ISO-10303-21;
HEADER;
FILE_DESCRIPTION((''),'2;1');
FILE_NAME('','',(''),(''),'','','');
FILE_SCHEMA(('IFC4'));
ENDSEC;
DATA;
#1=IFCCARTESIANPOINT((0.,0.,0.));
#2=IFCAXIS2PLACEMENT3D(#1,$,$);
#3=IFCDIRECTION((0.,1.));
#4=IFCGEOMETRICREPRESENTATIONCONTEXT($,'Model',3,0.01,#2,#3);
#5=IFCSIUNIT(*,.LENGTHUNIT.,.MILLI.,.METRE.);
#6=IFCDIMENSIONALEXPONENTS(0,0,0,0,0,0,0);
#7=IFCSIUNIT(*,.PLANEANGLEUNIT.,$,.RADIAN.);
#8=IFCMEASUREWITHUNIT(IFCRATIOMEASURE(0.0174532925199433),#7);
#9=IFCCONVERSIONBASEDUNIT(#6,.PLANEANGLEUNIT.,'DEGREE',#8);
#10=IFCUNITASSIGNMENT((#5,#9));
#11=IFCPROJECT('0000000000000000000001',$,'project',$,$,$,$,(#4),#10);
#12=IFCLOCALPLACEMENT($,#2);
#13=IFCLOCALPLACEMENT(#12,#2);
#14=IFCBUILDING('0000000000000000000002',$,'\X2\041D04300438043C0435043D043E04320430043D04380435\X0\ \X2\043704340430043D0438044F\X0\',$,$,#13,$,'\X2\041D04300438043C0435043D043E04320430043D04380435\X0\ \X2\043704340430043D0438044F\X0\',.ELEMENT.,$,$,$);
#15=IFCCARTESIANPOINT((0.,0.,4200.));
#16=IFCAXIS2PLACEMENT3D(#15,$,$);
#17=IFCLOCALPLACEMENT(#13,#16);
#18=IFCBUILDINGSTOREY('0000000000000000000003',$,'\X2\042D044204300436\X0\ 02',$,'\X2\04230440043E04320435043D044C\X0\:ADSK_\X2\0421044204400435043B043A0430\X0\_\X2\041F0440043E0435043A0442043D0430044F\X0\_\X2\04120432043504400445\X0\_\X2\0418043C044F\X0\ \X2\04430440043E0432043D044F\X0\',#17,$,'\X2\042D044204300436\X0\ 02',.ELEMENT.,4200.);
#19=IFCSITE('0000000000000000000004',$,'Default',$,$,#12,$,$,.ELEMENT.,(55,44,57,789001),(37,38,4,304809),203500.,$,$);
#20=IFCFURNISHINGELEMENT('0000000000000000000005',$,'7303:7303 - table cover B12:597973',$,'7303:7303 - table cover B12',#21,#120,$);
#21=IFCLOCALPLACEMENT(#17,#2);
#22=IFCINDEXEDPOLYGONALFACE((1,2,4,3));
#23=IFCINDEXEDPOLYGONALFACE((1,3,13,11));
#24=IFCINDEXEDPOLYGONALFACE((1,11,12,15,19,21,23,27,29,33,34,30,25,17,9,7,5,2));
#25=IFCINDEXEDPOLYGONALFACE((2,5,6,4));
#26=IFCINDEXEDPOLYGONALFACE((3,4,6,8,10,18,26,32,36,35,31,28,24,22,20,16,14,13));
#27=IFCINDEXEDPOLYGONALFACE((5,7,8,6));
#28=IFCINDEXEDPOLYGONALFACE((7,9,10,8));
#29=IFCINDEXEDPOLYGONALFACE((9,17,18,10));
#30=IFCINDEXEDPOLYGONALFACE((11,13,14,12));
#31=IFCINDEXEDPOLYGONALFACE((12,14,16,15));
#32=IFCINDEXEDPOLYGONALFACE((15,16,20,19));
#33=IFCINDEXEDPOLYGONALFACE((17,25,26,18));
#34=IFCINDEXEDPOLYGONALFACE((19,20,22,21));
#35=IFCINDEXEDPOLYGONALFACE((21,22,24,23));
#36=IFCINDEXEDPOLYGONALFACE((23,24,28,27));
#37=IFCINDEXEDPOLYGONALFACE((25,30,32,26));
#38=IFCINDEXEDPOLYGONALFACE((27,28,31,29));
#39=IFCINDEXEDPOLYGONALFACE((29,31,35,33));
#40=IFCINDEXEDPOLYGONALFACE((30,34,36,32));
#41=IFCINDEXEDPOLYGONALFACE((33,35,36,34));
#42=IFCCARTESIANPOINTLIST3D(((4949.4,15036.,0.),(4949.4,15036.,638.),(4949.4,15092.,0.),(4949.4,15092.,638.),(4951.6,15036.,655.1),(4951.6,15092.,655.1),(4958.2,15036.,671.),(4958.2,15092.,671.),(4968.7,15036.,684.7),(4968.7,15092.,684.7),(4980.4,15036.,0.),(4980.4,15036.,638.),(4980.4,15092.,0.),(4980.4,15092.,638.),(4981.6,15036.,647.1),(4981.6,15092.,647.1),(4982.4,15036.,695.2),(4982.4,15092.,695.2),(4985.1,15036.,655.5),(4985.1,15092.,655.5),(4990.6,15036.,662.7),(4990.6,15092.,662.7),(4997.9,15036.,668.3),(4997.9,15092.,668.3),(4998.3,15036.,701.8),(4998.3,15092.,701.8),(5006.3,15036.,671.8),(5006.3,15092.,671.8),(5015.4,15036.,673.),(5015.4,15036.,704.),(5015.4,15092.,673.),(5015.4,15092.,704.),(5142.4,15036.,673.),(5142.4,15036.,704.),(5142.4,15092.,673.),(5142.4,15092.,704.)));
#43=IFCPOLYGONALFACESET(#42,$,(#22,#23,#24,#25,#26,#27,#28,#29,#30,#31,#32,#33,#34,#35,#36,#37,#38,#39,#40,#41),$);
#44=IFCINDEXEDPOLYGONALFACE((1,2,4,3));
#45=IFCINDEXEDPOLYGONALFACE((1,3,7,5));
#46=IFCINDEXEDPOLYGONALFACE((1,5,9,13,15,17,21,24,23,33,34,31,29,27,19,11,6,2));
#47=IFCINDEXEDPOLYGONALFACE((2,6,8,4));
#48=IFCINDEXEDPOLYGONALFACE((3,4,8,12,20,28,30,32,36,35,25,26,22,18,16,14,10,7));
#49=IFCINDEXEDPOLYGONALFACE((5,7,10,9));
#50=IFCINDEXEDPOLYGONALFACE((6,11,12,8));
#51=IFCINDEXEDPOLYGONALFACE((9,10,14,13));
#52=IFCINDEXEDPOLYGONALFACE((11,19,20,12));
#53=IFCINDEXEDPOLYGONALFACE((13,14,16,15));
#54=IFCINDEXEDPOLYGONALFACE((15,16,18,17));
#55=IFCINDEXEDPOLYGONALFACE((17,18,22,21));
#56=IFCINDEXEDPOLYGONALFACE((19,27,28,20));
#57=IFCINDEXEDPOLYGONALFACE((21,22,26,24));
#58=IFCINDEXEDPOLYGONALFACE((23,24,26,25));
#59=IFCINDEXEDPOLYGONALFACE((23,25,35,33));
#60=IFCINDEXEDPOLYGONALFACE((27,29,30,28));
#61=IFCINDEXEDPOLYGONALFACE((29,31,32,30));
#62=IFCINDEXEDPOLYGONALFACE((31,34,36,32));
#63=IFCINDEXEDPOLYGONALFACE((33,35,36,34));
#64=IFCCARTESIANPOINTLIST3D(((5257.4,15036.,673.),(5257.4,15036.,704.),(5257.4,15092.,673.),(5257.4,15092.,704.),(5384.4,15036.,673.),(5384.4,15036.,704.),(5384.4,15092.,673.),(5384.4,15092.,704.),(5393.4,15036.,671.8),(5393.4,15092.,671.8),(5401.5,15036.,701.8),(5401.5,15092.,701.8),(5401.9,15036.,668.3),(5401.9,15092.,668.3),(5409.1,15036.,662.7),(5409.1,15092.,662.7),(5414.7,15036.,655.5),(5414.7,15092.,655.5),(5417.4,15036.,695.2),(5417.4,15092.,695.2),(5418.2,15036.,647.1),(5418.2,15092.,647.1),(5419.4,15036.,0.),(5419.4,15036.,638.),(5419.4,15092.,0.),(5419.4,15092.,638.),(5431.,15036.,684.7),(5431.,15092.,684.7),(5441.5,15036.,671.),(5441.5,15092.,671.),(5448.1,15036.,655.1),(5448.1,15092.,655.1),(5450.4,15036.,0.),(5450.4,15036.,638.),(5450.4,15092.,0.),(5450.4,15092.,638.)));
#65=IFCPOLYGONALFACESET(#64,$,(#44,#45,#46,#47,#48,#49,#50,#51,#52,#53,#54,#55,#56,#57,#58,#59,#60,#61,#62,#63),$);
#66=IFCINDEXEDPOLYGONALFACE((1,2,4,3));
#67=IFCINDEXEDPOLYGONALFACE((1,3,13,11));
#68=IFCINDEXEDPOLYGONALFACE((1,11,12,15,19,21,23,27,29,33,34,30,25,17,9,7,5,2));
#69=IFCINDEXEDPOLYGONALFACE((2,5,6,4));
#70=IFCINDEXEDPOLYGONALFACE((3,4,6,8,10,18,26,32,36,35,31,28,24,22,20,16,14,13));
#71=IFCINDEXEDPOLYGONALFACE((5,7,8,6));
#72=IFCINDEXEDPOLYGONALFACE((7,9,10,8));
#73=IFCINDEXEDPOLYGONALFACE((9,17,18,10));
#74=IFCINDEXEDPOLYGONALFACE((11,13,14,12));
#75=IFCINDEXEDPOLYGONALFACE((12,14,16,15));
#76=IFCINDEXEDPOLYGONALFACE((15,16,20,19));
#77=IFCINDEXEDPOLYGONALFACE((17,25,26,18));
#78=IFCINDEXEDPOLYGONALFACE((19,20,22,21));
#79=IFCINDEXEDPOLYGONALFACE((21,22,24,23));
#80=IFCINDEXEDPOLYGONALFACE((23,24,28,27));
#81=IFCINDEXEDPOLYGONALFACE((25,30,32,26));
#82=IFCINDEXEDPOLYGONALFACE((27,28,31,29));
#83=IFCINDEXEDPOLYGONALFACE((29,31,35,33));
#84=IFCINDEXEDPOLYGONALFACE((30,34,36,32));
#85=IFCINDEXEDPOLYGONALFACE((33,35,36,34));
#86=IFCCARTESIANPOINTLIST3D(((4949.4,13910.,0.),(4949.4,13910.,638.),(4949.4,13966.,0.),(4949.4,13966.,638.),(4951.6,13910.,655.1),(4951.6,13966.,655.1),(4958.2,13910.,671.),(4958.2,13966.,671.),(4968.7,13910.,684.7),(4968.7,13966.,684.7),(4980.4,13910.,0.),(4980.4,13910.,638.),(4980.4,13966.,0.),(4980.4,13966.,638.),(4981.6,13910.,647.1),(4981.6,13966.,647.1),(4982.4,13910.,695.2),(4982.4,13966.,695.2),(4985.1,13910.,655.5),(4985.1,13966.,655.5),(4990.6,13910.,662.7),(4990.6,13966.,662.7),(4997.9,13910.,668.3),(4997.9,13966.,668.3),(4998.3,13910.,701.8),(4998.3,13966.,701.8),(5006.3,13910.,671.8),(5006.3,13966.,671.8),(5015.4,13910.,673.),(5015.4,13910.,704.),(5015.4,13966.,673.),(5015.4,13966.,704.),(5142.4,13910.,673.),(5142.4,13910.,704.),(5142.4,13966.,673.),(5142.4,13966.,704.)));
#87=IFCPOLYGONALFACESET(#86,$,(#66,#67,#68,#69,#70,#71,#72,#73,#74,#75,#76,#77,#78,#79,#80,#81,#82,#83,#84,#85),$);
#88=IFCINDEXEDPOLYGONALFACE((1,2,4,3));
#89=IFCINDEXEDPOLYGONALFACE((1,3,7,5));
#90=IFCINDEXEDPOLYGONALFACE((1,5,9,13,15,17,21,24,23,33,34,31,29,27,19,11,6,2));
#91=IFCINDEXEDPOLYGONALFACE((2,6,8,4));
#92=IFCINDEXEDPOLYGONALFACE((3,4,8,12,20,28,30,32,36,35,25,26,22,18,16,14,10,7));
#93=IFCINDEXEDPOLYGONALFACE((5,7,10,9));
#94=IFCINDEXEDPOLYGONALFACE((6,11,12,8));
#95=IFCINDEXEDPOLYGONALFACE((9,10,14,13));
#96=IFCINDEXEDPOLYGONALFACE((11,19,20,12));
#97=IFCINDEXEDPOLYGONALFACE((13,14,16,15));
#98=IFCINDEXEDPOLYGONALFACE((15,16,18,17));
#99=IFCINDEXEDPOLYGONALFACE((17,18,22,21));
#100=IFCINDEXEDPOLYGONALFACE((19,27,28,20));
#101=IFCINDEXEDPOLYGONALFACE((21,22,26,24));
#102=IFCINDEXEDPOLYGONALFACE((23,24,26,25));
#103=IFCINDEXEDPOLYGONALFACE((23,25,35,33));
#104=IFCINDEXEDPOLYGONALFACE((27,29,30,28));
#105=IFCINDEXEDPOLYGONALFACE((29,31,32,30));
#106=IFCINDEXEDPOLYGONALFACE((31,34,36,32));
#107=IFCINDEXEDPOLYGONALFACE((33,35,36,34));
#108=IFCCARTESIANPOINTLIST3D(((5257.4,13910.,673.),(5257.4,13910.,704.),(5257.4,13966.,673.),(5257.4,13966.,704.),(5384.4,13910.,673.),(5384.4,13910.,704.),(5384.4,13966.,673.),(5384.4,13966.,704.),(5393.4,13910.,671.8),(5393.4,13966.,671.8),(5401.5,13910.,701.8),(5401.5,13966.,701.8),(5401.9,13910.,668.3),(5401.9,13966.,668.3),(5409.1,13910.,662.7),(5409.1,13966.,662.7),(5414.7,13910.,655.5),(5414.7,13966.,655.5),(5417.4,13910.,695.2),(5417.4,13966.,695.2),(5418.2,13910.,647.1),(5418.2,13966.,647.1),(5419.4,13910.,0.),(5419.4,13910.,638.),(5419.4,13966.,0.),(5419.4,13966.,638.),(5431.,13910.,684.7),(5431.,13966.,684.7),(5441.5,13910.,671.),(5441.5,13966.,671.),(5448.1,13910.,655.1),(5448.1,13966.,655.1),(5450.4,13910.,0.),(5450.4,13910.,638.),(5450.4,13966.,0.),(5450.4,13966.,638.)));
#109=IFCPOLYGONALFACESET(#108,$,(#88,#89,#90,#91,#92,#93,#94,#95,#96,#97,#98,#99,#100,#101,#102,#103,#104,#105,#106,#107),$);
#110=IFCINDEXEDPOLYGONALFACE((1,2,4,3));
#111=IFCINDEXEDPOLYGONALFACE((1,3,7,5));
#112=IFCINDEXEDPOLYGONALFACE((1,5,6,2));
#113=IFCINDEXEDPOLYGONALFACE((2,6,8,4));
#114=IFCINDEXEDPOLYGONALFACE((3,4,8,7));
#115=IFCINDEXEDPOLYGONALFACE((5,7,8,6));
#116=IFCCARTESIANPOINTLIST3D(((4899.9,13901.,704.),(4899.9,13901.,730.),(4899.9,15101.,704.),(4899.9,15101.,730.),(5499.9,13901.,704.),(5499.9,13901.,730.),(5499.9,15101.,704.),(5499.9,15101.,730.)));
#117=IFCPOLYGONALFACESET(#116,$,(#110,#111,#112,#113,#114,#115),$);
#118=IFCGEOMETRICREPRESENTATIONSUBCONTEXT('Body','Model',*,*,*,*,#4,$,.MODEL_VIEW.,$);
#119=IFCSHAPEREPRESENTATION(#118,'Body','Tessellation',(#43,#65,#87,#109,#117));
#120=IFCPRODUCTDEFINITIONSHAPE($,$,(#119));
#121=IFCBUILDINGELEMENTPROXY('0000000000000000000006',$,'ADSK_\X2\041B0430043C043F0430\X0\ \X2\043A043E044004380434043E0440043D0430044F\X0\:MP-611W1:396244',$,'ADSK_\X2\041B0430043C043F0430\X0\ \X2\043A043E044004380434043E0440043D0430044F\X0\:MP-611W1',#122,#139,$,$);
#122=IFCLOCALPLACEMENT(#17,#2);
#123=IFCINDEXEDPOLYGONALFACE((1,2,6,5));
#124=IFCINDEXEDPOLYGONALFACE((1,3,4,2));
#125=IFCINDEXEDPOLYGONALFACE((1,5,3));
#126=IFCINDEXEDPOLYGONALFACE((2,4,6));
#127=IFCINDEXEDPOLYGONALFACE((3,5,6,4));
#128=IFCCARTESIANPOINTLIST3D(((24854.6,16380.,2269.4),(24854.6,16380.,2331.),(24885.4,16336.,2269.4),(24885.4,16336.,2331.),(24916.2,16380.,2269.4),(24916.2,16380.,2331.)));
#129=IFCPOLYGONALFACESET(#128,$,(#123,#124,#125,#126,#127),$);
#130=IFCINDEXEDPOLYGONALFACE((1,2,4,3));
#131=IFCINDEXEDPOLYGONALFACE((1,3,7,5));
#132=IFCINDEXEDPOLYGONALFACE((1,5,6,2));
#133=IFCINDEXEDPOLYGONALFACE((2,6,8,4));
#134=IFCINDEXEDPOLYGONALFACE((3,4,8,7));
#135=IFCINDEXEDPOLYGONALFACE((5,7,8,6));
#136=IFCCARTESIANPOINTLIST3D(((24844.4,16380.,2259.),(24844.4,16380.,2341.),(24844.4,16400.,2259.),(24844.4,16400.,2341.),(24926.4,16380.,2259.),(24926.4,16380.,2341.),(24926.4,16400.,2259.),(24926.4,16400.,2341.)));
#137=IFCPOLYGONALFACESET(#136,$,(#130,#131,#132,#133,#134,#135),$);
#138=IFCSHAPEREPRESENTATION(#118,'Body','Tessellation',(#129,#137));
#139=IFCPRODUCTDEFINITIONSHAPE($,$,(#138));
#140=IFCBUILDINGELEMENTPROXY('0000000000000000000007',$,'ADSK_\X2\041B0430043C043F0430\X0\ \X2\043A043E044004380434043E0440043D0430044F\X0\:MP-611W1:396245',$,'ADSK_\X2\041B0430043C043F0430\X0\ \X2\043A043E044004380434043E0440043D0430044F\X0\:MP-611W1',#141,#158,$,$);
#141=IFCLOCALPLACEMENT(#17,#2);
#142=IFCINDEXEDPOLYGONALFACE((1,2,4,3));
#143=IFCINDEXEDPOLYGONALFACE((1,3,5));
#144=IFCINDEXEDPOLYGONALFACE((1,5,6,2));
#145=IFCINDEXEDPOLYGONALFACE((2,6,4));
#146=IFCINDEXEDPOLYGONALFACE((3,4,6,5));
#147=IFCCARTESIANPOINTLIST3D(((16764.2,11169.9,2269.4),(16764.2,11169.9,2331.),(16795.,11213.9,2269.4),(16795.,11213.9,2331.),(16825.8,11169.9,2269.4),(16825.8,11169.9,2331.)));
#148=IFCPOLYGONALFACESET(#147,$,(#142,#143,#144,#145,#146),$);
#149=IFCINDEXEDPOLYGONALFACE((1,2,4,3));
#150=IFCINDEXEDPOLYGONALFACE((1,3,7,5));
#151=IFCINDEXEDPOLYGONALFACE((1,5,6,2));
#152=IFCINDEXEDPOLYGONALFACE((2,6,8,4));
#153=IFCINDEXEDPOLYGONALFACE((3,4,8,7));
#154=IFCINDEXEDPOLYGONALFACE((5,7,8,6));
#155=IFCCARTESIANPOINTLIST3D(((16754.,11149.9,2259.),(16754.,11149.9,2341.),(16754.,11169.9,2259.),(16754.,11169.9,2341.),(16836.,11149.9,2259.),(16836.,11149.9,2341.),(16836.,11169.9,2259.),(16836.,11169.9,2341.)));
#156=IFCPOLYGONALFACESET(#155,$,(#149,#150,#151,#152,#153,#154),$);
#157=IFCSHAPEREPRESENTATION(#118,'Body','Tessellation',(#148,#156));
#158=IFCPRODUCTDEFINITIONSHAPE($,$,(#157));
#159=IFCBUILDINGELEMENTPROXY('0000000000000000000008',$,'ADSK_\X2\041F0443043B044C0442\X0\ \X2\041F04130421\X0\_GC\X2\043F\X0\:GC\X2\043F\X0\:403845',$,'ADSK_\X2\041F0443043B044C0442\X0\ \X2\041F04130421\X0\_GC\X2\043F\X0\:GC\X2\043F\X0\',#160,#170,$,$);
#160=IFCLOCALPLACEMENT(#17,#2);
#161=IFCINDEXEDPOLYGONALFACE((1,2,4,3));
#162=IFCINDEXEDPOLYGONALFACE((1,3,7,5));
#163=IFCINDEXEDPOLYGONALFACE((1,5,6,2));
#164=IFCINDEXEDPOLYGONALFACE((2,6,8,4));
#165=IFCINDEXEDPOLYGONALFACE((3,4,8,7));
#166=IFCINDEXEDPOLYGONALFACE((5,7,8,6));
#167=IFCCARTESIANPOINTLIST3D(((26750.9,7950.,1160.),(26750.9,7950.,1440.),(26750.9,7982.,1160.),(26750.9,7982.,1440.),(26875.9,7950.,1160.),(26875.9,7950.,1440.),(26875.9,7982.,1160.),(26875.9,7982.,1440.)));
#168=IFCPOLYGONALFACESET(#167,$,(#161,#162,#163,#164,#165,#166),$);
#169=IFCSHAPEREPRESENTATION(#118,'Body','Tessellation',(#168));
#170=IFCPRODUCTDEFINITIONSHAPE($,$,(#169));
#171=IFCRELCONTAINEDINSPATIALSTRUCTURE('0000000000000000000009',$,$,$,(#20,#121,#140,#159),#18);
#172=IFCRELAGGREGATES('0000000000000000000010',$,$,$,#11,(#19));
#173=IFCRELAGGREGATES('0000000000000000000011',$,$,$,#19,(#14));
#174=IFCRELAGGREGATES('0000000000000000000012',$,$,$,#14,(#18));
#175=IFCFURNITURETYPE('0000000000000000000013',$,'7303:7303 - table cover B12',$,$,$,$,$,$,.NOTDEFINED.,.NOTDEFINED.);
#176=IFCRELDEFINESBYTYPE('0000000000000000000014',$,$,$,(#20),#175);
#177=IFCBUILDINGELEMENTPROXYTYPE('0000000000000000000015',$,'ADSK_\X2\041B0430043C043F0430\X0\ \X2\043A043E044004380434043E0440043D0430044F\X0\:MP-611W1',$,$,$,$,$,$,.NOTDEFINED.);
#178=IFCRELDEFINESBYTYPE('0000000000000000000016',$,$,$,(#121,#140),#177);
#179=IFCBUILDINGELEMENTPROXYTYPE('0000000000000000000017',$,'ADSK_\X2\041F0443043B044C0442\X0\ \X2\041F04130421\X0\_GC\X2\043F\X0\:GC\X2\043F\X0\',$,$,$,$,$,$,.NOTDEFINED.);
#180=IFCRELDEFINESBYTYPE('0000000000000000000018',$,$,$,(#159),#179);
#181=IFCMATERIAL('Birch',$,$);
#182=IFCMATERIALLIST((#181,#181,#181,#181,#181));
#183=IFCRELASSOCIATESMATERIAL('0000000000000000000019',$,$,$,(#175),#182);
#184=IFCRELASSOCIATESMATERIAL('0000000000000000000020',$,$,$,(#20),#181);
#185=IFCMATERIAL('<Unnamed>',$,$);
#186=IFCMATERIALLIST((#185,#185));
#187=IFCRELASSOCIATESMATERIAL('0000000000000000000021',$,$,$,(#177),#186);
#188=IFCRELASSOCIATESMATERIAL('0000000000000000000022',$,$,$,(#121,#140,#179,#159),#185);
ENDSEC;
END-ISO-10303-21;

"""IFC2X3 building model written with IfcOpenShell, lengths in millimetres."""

from ifc_helpers import new_model, entity, si_unit, converted_unit, direction, frame, frame_2d, origin, origin_2d_with_axis, place, context, subcontext, project, spatial, polyline, circle_curve, parameter, trimmed, segment, composite_curve, rectangle, outline, extrude, source, transform, mapped, material, material_list, type_object, type_shapes, element, save


model = new_model("IFC2X3")

# Units and contexts
model_context = context("Model", 3, precision=0.01, world=origin(), true_north=direction((0.0, 1.0)))
body_context = subcontext(model_context, "Body", "Model", "MODEL_VIEW")
ifc_project = project(units=[si_unit("LENGTHUNIT", "METRE", prefix="MILLI"), converted_unit("PLANEANGLEUNIT", "DEGREE", entity("IfcRatioMeasure", 0.0174532925199433), si_unit("PLANEANGLEUNIT", "RADIAN"), dimensions=[0, 0, 0, 0, 0, 0, 0])], contexts=[model_context])

# Site, building, storey
site_placement = place(None, origin())
site = spatial("IfcSite", under=ifc_project, at=site_placement, Name="Default", CompositionType="ELEMENT", RefLatitude=(55, 44, 57, 789001), RefLongitude=(37, 38, 4, 304809), RefElevation=203500.0)
building_placement = place(site_placement, origin())
building = spatial("IfcBuilding", under=site, at=building_placement, Name="Наименование здания", LongName="Наименование здания", CompositionType="ELEMENT")
storey_placement = place(building_placement, frame((0.0, 0.0, 4200.0)))
storey = spatial("IfcBuildingStorey", under=building, at=storey_placement, Name="Этаж 02", ObjectType="Уровень:ADSK_Стрелка_Проектная_Вверх_Имя уровня", LongName="Этаж 02", CompositionType="ELEMENT", Elevation=4200.0)

# Furnishing element
ifc_material_1 = material(Name="Birch")
ifc_material_list_1 = material_list([ifc_material_1, ifc_material_1, ifc_material_1, ifc_material_1, ifc_material_1])
furniture_type_1 = type_object("IfcFurnitureType", Name="7303:7303 - table cover B12", material=ifc_material_list_1)
shared_shape_1 = source(origin(), body_context, "Body", "SweptSolid", [
    extrude(outline(composite_curve([segment(polyline([(-200.2, -120.5), (-169.2, -120.5)]), True, "CONTINUOUS"), segment(polyline([(-169.2, -120.5), (-169.2, 6.5)]), True, "CONTINUOUS"), segment(trimmed(circle_curve(frame_2d((-134.2, 6.5), x_axis=(0.0, -1.0)), 35.0), [parameter(180.0)], [parameter(270.0)], True, "PARAMETER"), False, "CONTINUOUS"), segment(polyline([(-134.2, 41.5), (503.8, 41.5)]), True, "CONTINUOUS"), segment(polyline([(503.8, 41.5), (503.8, 72.5)]), True, "CONTINUOUS"), segment(polyline([(503.8, 72.5), (-134.2, 72.5)]), True, "CONTINUOUS"), segment(trimmed(circle_curve(frame_2d((-134.2, 6.5), x_axis=(0.0, -1.0)), 66.0), [parameter(180.0)], [parameter(270.0)], True, "PARAMETER"), True, "CONTINUOUS"), segment(polyline([(-200.2, 6.5), (-200.2, -120.5)]), True, "CONTINUOUS")], self_intersect=False)), frame((535.0, 178.0, 503.8), z_axis=(1.0, 0.0, 0.0), x_axis=(0.0, 0.0, -1.0)), (0.0, 0.0, 1.0), 56.0),
    extrude(outline(composite_curve([segment(polyline([(-120.5, -200.2), (6.5, -200.2)]), True, "CONTINUOUS"), segment(trimmed(circle_curve(frame_2d((6.5, -134.2), x_axis=(-1.0, 0.0)), 66.0), [parameter(90.0)], [parameter(180.0)], True, "PARAMETER"), True, "CONTINUOUS"), segment(polyline([(72.5, -134.2), (72.5, 503.8)]), True, "CONTINUOUS"), segment(polyline([(72.5, 503.8), (41.5, 503.8)]), True, "CONTINUOUS"), segment(polyline([(41.5, 503.8), (41.5, -134.2)]), True, "CONTINUOUS"), segment(trimmed(circle_curve(frame_2d((6.5, -134.2), x_axis=(-1.0, 0.0)), 35.0), [parameter(90.0)], [parameter(180.0)], True, "PARAMETER"), False, "CONTINUOUS"), segment(polyline([(6.5, -169.2), (-120.5, -169.2)]), True, "CONTINUOUS"), segment(polyline([(-120.5, -169.2), (-120.5, -200.2)]), True, "CONTINUOUS")], self_intersect=False)), frame((535.0, -178.0, 503.8), z_axis=(1.0, 0.0, 0.0), x_axis=(0.0, -1.0, 0.0)), (0.0, 0.0, 1.0), 56.0),
    extrude(outline(composite_curve([segment(polyline([(-200.2, -120.5), (-169.2, -120.5)]), True, "CONTINUOUS"), segment(polyline([(-169.2, -120.5), (-169.2, 6.5)]), True, "CONTINUOUS"), segment(trimmed(circle_curve(frame_2d((-134.2, 6.5), x_axis=(0.0, -1.0)), 35.0), [parameter(180.0)], [parameter(270.0)], True, "PARAMETER"), False, "CONTINUOUS"), segment(polyline([(-134.2, 41.5), (503.8, 41.5)]), True, "CONTINUOUS"), segment(polyline([(503.8, 41.5), (503.8, 72.5)]), True, "CONTINUOUS"), segment(polyline([(503.8, 72.5), (-134.2, 72.5)]), True, "CONTINUOUS"), segment(trimmed(circle_curve(frame_2d((-134.2, 6.5), x_axis=(0.0, -1.0)), 66.0), [parameter(180.0)], [parameter(270.0)], True, "PARAMETER"), True, "CONTINUOUS"), segment(polyline([(-200.2, 6.5), (-200.2, -120.5)]), True, "CONTINUOUS")], self_intersect=False)), frame((-591.0, 178.0, 503.8), z_axis=(1.0, 0.0, 0.0), x_axis=(0.0, 0.0, -1.0)), (0.0, 0.0, 1.0), 56.0),
    extrude(outline(composite_curve([segment(polyline([(-120.5, -200.2), (6.5, -200.2)]), True, "CONTINUOUS"), segment(trimmed(circle_curve(frame_2d((6.5, -134.2), x_axis=(-1.0, 0.0)), 66.0), [parameter(90.0)], [parameter(180.0)], True, "PARAMETER"), True, "CONTINUOUS"), segment(polyline([(72.5, -134.2), (72.5, 503.8)]), True, "CONTINUOUS"), segment(polyline([(72.5, 503.8), (41.5, 503.8)]), True, "CONTINUOUS"), segment(polyline([(41.5, 503.8), (41.5, -134.2)]), True, "CONTINUOUS"), segment(trimmed(circle_curve(frame_2d((6.5, -134.2), x_axis=(-1.0, 0.0)), 35.0), [parameter(90.0)], [parameter(180.0)], True, "PARAMETER"), False, "CONTINUOUS"), segment(polyline([(6.5, -169.2), (-120.5, -169.2)]), True, "CONTINUOUS"), segment(polyline([(-120.5, -169.2), (-120.5, -200.2)]), True, "CONTINUOUS")], self_intersect=False)), frame((-591.0, -178.0, 503.8), z_axis=(1.0, 0.0, 0.0), x_axis=(0.0, -1.0, 0.0)), (0.0, 0.0, 1.0), 56.0),
    extrude(rectangle(XDim=1200.0, YDim=600.0, at=origin_2d_with_axis()), frame((0.0, 0.0, 704.0), z_axis=(0.0, 0.0, 1.0), x_axis=(-1.0, 0.0, 0.0)), (0.0, 0.0, 1.0), 26.0),
])
type_shapes(furniture_type_1, [shared_shape_1])
for number, where, z_axis, x_axis, name in (
    (1, (5199.9, 14501.0, 0.0), (0.0, 0.0, 1.0), (0.0, 1.0, 0.0), "7303:7303 - table cover B12:597973"),
):
    element("IfcFurnishingElement", number, at=place(storey_placement, frame(where, z_axis=z_axis, x_axis=x_axis)), inside=storey, type_object=furniture_type_1, material=ifc_material_1, Name=name, ObjectType="7303:7303 - table cover B12", context=body_context, shape_type="MappedRepresentation", body=[
        mapped(shared_shape_1, transform((0.0, 0.0, 0.0), scale=1.0)),
    ])

# Building element proxies
ifc_material_2 = material(Name="<Unnamed>")
ifc_material_list_2 = material_list([ifc_material_2, ifc_material_2])
building_element_proxy_type_1 = type_object("IfcBuildingElementProxyType", Name="ADSK_Лампа коридорная:MP-611W1", PredefinedType="NOTDEFINED", material=ifc_material_list_2)
shared_shape_2 = source(origin(), body_context, "Body", "SweptSolid", [
    extrude(outline(polyline([(-30.8, -14.7), (30.8, -14.7), (0.0, 29.3), (-30.8, -14.7)])), frame((0.0, -2.7, -30.6), z_axis=(0.0, 0.0, 1.0), x_axis=(-1.0, 0.0, 0.0)), (0.0, 0.0, 1.0), 61.6),
    extrude(rectangle(XDim=82.0, YDim=20.0, at=origin_2d_with_axis()), frame((0.0, 22.0, -41.0), z_axis=(0.0, 0.0, 1.0), x_axis=(-1.0, 0.0, 0.0)), (0.0, 0.0, 1.0), 82.0),
])
type_shapes(building_element_proxy_type_1, [shared_shape_2])
proxy_1_placement = place(storey_placement, frame((24885.4, 16368.0, 2300.0)))
element("IfcBuildingElementProxy", 2, at=proxy_1_placement, inside=storey, type_object=building_element_proxy_type_1, material=ifc_material_2, Name="ADSK_Лампа коридорная:MP-611W1:396244", ObjectType="ADSK_Лампа коридорная:MP-611W1", context=body_context, shape_type="MappedRepresentation", body=[
    mapped(shared_shape_2, transform((0.0, 0.0, 0.0), scale=1.0)),
])
proxy_2_placement = place(storey_placement, frame((16795.0, 11181.9, 2300.0), z_axis=(0.0, 0.0, 1.0), x_axis=(-1.0, 0.0, 0.0)))
element("IfcBuildingElementProxy", 3, at=proxy_2_placement, inside=storey, type_object=building_element_proxy_type_1, material=ifc_material_2, Name="ADSK_Лампа коридорная:MP-611W1:396245", ObjectType="ADSK_Лампа коридорная:MP-611W1", context=body_context, shape_type="MappedRepresentation", body=[
    mapped(shared_shape_2, transform((0.0, 0.0, 0.0), scale=1.0)),
])
building_element_proxy_type_2 = type_object("IfcBuildingElementProxyType", Name="ADSK_Пульт ПГС_GCп:GCп", PredefinedType="NOTDEFINED", material=ifc_material_2)
shared_shape_3 = source(origin(), body_context, "Body", "SweptSolid", [
    extrude(rectangle(XDim=125.0, YDim=32.0, at=origin_2d_with_axis()), frame((0.0, 16.0, -140.0), z_axis=(0.0, 0.0, 1.0), x_axis=(-1.0, 0.0, 0.0)), (0.0, 0.0, 1.0), 280.0),
])
type_shapes(building_element_proxy_type_2, [shared_shape_3])
proxy_3_placement = place(storey_placement, frame((26813.4, 7982.0, 1300.0), z_axis=(0.0, 0.0, 1.0), x_axis=(-1.0, 0.0, 0.0)))
element("IfcBuildingElementProxy", 4, at=proxy_3_placement, inside=storey, type_object=building_element_proxy_type_2, material=ifc_material_2, Name="ADSK_Пульт ПГС_GCп:GCп:403845", ObjectType="ADSK_Пульт ПГС_GCп:GCп", context=body_context, shape_type="MappedRepresentation", body=[
    mapped(shared_shape_3, transform((0.0, 0.0, 0.0), scale=1.0)),
])

save(model, "model.ifc")
